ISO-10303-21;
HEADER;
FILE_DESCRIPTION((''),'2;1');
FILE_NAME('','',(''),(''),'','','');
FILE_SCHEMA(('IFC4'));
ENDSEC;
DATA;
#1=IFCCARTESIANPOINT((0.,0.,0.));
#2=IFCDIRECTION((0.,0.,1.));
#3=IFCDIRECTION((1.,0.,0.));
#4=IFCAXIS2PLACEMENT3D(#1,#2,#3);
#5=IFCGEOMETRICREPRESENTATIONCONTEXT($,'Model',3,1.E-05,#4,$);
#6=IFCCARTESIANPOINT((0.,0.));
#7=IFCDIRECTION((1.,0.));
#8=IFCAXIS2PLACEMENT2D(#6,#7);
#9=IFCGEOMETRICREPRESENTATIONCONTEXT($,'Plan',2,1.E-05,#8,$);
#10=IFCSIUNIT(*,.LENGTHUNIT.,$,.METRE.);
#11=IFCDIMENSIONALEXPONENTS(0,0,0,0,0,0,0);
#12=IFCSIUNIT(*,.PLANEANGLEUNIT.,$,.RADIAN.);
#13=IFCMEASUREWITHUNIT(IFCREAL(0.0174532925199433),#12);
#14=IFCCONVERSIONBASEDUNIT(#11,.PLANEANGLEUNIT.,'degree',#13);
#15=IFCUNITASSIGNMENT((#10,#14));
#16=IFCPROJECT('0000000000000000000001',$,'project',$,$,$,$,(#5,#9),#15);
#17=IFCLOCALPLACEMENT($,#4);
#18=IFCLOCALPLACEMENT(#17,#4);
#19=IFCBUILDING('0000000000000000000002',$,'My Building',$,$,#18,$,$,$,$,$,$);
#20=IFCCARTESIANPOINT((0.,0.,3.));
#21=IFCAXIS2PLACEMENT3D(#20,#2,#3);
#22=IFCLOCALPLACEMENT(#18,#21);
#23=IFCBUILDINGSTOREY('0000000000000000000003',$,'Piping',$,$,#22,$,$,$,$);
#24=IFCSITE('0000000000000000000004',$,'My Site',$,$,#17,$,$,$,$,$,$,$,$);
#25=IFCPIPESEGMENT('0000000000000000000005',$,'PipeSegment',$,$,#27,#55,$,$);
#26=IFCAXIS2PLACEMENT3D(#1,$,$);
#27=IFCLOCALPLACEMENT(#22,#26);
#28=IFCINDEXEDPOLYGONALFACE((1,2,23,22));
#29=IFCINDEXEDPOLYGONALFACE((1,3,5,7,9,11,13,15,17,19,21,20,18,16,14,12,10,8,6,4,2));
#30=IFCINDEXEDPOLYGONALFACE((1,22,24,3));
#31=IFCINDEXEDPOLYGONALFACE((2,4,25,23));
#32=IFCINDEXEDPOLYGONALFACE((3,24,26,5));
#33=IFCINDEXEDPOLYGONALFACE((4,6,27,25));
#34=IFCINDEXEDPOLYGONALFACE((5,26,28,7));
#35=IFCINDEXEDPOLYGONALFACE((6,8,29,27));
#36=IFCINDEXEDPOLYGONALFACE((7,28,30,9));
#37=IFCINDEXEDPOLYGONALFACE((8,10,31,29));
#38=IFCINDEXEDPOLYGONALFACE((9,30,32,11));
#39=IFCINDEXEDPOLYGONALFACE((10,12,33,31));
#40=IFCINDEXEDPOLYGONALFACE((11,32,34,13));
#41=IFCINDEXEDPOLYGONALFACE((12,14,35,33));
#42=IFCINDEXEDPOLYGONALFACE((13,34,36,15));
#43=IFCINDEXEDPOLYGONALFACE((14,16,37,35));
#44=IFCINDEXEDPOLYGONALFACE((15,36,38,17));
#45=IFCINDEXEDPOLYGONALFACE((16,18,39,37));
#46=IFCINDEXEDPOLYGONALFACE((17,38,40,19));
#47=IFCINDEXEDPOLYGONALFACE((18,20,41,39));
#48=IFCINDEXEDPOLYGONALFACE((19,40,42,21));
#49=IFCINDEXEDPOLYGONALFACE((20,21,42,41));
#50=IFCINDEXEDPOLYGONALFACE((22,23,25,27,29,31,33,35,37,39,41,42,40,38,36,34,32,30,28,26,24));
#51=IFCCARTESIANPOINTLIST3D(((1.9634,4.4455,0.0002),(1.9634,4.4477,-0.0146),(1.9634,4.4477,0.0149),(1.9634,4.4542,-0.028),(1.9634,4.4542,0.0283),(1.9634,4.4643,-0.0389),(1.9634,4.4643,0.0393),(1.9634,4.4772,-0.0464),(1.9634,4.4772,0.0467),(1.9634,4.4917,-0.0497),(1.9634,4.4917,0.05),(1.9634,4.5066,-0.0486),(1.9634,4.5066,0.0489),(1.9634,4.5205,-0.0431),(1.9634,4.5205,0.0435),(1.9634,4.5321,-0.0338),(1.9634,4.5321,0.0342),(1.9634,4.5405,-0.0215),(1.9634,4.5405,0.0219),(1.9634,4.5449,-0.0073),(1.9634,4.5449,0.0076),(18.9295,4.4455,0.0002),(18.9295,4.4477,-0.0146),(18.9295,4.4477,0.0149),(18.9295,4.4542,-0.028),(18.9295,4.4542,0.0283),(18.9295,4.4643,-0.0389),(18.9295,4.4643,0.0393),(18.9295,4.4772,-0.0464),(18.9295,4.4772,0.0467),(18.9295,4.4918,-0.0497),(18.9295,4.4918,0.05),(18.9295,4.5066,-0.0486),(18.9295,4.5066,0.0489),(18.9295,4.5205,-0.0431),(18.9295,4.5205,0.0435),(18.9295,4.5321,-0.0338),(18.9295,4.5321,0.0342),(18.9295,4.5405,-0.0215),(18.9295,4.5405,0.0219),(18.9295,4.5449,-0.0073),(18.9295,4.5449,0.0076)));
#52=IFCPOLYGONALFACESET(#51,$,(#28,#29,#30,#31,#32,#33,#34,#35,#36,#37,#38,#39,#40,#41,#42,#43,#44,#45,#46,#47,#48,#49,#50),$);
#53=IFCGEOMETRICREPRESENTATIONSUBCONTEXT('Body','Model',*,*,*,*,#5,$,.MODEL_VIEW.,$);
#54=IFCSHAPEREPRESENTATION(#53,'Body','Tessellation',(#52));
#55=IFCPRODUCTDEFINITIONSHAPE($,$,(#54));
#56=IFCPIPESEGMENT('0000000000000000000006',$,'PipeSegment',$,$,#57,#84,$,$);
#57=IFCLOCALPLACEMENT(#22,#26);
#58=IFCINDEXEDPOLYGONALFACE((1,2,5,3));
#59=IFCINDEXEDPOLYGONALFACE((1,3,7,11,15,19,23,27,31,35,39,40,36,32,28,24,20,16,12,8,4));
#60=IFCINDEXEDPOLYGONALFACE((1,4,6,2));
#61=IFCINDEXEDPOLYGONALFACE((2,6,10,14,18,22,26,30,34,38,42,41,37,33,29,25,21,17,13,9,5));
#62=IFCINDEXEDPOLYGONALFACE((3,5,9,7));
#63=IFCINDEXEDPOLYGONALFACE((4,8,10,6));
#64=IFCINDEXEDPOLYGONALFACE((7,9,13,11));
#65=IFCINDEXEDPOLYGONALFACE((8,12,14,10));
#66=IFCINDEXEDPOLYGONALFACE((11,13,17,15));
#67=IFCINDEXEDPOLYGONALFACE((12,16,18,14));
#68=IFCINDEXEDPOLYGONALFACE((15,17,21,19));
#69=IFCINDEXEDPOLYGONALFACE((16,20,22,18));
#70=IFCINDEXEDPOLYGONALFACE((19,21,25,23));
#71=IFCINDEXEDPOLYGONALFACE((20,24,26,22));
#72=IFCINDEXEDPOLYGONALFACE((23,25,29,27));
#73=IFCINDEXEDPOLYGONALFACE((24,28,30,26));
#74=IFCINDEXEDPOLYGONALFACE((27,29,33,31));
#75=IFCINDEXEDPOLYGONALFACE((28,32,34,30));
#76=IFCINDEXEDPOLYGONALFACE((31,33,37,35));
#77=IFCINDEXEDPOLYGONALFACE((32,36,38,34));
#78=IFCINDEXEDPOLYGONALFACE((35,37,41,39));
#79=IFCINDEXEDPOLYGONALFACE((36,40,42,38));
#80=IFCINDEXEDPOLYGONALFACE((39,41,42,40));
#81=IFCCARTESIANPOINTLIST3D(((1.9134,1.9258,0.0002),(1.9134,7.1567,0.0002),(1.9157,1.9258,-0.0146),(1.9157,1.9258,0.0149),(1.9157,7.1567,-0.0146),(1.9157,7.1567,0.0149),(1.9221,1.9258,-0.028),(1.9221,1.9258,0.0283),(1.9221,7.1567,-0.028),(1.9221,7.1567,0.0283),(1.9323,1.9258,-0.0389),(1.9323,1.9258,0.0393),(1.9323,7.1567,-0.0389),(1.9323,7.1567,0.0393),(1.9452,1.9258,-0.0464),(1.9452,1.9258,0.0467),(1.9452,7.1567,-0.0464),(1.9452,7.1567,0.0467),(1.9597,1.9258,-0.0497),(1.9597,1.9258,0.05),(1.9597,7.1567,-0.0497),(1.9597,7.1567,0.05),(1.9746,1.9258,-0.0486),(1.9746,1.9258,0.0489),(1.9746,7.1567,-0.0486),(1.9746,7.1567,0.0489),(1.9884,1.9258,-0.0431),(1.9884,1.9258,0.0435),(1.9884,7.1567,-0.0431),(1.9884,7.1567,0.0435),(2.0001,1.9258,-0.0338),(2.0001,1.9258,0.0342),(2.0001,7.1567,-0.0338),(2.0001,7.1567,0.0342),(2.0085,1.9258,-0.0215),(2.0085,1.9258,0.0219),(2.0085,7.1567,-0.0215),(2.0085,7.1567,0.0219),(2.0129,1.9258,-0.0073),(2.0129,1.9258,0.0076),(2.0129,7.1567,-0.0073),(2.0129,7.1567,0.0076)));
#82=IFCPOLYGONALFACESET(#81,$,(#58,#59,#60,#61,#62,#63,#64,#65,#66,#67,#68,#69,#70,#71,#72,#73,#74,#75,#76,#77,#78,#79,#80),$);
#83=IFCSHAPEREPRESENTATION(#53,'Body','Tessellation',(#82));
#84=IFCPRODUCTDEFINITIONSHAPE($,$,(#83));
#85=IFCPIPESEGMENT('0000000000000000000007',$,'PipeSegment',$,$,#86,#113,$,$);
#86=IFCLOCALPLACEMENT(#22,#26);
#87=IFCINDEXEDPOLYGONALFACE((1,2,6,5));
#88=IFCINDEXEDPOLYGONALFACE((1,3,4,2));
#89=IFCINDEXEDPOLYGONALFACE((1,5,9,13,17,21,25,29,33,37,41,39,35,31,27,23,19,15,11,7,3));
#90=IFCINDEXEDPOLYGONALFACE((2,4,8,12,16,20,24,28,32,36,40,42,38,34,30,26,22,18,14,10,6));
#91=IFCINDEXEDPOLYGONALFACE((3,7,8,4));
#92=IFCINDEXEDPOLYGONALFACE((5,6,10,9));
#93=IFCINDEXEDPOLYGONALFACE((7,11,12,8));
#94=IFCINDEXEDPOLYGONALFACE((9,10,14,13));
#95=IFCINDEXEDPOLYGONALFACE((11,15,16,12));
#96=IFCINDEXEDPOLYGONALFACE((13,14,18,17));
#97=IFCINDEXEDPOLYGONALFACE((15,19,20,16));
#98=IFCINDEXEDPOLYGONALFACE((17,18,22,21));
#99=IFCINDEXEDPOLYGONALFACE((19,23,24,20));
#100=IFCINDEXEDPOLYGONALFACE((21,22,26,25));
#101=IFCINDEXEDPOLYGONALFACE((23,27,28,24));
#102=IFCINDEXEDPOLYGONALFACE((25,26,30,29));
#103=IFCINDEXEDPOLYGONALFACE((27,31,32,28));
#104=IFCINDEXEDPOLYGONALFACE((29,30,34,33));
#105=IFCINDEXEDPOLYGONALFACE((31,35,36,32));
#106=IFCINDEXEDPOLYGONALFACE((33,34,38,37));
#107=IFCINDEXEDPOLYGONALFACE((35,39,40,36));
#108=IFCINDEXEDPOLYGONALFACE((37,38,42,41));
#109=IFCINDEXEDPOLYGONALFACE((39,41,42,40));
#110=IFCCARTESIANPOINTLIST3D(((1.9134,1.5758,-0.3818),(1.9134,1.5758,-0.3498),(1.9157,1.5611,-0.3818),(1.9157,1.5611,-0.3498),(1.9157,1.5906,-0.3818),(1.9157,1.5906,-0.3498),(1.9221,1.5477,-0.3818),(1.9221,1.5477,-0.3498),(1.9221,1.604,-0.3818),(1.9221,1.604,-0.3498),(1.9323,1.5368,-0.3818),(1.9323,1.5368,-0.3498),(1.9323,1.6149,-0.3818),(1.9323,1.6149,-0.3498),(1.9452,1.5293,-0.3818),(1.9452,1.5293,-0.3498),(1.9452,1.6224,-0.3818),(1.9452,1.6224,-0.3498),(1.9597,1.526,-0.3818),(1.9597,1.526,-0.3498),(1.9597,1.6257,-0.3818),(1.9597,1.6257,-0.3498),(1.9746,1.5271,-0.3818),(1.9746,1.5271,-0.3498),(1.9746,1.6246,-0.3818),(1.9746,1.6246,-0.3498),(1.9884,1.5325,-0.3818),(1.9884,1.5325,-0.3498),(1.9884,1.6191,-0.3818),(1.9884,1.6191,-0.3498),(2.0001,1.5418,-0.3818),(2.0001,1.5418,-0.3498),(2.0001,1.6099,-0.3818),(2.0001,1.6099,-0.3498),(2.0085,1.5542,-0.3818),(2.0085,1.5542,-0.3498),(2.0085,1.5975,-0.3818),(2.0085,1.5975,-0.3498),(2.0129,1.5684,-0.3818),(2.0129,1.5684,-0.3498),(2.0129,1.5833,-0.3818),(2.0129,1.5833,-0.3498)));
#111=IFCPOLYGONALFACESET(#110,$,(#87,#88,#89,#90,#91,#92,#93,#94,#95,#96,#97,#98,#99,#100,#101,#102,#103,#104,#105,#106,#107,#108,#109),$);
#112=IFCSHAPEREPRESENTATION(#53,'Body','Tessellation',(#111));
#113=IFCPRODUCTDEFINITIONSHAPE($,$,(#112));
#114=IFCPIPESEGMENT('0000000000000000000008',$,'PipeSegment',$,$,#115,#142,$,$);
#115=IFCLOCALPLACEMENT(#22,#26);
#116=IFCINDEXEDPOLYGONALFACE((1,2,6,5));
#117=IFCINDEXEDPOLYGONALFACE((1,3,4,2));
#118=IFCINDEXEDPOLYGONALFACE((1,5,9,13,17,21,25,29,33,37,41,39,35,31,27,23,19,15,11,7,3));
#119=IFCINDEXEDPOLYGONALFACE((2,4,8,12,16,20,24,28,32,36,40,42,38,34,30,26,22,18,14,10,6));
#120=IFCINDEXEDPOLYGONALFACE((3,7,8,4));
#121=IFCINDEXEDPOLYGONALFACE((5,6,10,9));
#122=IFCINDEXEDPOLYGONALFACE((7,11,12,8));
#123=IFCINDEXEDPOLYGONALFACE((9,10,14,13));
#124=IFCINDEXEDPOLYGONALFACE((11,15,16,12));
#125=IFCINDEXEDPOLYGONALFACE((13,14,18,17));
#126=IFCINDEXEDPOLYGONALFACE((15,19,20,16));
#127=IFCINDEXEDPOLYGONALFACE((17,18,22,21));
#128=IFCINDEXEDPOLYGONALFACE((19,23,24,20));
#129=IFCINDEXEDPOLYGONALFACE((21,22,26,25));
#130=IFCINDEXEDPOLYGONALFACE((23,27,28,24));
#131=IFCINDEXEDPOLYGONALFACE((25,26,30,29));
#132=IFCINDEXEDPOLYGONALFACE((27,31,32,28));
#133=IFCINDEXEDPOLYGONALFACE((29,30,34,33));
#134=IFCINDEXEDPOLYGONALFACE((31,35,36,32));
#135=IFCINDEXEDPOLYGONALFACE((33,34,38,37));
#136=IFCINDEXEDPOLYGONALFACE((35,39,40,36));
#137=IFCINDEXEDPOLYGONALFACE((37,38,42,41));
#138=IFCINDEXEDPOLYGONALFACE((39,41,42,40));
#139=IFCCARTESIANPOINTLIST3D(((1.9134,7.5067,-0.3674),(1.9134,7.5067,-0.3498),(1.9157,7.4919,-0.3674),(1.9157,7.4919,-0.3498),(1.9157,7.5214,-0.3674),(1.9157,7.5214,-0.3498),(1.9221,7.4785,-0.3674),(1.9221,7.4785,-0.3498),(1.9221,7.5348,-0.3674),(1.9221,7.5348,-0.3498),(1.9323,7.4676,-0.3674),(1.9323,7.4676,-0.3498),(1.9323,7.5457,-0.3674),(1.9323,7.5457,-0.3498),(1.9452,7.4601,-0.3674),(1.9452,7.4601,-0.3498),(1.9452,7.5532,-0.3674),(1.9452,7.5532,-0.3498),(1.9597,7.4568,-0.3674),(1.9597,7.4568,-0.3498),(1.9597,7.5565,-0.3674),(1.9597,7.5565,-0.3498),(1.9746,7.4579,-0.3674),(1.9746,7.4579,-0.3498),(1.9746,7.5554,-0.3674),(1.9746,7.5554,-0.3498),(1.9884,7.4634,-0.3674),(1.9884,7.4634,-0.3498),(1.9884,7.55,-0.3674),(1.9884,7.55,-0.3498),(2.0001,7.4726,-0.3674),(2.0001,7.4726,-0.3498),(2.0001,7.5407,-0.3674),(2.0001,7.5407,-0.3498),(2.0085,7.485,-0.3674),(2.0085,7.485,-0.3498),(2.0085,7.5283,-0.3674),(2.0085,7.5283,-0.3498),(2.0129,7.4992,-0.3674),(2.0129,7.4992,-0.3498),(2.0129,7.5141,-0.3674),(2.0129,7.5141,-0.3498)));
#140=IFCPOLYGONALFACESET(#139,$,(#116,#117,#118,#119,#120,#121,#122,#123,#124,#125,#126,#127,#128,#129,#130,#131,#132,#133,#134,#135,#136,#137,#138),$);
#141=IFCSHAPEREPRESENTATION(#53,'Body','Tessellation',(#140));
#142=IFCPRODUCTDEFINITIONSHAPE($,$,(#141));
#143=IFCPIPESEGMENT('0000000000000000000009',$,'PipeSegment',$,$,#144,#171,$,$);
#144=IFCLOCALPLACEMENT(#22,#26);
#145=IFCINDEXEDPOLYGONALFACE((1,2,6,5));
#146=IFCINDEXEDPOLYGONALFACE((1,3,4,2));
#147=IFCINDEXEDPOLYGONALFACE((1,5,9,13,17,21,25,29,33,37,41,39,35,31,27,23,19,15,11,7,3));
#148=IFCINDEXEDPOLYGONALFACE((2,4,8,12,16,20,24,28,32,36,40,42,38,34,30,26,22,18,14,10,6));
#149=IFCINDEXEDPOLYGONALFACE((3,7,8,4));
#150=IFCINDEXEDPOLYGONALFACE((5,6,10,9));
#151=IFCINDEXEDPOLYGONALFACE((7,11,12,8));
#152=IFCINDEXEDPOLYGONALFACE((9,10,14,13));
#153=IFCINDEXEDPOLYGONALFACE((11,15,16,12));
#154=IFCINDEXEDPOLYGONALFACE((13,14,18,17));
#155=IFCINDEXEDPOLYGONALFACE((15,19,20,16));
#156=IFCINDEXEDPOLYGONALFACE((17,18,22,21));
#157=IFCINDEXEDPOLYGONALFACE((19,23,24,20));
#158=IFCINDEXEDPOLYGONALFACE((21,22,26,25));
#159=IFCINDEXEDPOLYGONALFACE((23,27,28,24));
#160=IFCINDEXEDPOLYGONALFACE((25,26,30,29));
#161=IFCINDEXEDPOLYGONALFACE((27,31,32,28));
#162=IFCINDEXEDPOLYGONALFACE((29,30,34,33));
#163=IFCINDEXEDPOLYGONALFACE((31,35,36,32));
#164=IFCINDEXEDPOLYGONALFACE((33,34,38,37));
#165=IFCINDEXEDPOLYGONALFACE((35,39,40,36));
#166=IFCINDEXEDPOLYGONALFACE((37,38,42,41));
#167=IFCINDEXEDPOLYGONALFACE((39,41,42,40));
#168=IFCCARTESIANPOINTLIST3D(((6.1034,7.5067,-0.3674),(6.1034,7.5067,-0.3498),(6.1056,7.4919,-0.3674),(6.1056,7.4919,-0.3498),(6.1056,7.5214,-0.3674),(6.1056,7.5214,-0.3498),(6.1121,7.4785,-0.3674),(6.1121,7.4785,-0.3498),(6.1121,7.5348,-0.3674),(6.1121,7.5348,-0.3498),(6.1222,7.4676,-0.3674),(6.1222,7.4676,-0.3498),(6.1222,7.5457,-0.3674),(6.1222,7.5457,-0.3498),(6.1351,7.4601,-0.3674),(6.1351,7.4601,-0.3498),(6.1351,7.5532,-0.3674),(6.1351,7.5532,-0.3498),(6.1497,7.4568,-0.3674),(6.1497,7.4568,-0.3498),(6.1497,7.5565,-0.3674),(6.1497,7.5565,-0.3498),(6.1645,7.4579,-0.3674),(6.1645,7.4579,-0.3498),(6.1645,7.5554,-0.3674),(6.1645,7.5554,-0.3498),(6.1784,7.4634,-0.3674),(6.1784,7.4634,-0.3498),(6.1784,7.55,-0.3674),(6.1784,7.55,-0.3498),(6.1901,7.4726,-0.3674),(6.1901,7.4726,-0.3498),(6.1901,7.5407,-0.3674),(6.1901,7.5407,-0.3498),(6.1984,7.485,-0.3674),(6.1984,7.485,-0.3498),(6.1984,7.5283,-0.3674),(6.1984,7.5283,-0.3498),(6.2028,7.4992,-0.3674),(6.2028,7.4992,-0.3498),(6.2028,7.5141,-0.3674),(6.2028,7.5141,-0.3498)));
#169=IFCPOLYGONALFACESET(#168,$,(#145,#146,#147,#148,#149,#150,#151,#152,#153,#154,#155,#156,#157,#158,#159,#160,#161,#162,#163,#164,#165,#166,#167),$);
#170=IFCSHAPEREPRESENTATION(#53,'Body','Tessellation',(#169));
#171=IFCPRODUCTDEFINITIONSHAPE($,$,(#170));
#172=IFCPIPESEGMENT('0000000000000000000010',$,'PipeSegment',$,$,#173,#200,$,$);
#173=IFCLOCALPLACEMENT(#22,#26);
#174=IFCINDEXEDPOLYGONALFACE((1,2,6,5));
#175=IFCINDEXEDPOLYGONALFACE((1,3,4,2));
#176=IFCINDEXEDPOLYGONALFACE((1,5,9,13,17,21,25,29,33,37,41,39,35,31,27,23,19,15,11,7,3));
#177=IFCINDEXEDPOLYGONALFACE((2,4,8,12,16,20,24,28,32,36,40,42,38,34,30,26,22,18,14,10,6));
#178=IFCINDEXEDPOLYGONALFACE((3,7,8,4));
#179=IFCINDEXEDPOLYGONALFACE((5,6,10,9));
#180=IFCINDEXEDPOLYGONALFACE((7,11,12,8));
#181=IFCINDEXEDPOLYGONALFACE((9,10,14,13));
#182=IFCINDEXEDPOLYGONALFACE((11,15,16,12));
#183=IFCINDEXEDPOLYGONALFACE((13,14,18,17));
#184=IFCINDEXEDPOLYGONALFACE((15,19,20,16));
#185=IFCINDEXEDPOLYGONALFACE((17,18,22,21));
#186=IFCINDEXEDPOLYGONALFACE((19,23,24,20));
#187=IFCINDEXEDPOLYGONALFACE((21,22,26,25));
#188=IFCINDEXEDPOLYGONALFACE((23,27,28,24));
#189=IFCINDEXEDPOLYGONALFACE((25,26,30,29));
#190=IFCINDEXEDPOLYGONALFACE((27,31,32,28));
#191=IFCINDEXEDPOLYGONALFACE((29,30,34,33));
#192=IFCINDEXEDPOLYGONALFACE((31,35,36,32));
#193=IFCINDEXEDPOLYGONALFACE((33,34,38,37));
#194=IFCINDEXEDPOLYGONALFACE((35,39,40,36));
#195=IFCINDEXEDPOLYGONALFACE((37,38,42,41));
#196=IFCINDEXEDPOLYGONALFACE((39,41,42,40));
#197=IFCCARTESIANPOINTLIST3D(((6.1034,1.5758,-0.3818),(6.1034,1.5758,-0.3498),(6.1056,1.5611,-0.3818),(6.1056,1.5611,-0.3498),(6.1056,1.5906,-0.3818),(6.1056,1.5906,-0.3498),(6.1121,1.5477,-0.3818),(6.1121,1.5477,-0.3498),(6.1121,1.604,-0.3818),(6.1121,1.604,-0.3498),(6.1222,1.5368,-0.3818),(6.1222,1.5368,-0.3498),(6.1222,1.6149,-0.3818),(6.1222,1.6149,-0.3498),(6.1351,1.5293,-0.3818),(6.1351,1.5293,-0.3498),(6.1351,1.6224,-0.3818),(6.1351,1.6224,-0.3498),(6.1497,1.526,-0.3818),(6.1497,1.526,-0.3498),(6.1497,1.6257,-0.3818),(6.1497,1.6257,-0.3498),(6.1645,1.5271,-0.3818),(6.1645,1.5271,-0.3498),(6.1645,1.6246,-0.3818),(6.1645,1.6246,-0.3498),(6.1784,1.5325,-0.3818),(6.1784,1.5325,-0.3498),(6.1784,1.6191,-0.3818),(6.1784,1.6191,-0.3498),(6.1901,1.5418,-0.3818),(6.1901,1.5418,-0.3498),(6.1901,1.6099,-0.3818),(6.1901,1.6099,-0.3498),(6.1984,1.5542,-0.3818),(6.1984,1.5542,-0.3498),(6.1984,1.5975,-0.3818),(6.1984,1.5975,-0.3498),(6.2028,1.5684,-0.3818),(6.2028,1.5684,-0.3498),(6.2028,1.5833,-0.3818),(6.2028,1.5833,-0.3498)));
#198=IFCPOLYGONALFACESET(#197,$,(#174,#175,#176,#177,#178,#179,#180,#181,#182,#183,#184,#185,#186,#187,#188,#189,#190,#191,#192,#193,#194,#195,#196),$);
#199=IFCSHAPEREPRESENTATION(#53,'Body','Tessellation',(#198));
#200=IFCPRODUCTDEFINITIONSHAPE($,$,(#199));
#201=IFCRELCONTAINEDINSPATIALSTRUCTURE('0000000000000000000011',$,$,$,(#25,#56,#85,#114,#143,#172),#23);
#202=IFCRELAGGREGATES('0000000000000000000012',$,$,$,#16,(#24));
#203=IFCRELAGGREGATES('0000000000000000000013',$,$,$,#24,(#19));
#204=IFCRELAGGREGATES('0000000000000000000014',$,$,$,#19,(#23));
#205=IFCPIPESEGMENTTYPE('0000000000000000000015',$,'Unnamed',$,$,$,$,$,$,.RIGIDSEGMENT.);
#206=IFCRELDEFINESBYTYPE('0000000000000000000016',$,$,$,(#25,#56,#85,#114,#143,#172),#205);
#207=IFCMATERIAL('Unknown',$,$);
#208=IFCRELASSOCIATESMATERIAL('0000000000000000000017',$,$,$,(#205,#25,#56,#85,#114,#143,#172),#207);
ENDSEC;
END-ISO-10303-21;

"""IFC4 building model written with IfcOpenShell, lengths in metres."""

from ifc_helpers import new_model, entity, si_unit, converted_unit, frame, origin_with_axes, origin_2d_with_axis, place, context, subcontext, project, spatial, circle, extrude, material, material_profile, profile_set, profile_usage, type_object, element, save


model = new_model("IFC4")

# Units and contexts
model_context = context("Model", 3, precision=1e-05, world=origin_with_axes())
plan_context = context("Plan", 2, precision=1e-05, world=origin_2d_with_axis())
body_context = subcontext(model_context, "Body", "Model", "MODEL_VIEW")
ifc_project = project(units=[si_unit("LENGTHUNIT", "METRE"), converted_unit("PLANEANGLEUNIT", "degree", entity("IfcReal", 0.0174532925199433), si_unit("PLANEANGLEUNIT", "RADIAN"), dimensions=[0, 0, 0, 0, 0, 0, 0])], contexts=[model_context, plan_context])

# Site, building, storey
site_placement = place(None, origin_with_axes())
site = spatial("IfcSite", under=ifc_project, at=site_placement, Name="My Site")
building_placement = place(site_placement, origin_with_axes())
building = spatial("IfcBuilding", under=site, at=building_placement, Name="My Building")
storey_placement = place(building_placement, frame((0.0, 0.0, 3.0), z_axis=(0.0, 0.0, 1.0), x_axis=(1.0, 0.0, 0.0)))
storey = spatial("IfcBuildingStorey", under=building, at=storey_placement, Name="Piping")

# Pipe segments
ifc_material = material(Name="Unknown")
ifc_material_profile = material_profile(ifc_material, circle(Radius=0.05))
ifc_profile_set = profile_set([ifc_material_profile])
ifc_profile_usage_1 = profile_usage(ifc_profile_set, cardinal=5)
pipe_segment_type = type_object("IfcPipeSegmentType", Name="Unnamed", PredefinedType="RIGIDSEGMENT", material=ifc_profile_set)
pipe_segment_1_placement = place(storey_placement, frame((18.9295, 4.4955, 0.0002), z_axis=(-1.0, 0.0, 0.0), x_axis=(0.0, -1.0, 0.0)))
element("IfcPipeSegment", 1, at=pipe_segment_1_placement, inside=storey, type_object=pipe_segment_type, material=ifc_profile_usage_1, Name="PipeSegment", context=body_context, shape_type="SweptSolid", body=[
    extrude(circle(Radius=0.05), origin_with_axes(), (0.0, 0.0, 1.0), 16.966),
])
ifc_profile_usage_2 = profile_usage(ifc_profile_set, cardinal=5)
pipe_segment_2_placement = place(storey_placement, frame((1.9634, 1.9258, 0.0002), z_axis=(0.0, 1.0, 0.0), x_axis=(-1.0, 0.0, 0.0)))
element("IfcPipeSegment", 2, at=pipe_segment_2_placement, inside=storey, type_object=pipe_segment_type, material=ifc_profile_usage_2, Name="PipeSegment", context=body_context, shape_type="SweptSolid", body=[
    extrude(circle(Radius=0.05), origin_with_axes(), (0.0, 0.0, 1.0), 5.2308),
])
ifc_profile_usage_3 = profile_usage(ifc_profile_set, cardinal=5)
pipe_segment_3_placement = place(storey_placement, frame((1.9634, 1.5758, -0.3498), z_axis=(0.0, 0.0, -1.0), x_axis=(-1.0, 0.0, 0.0)))
element("IfcPipeSegment", 3, at=pipe_segment_3_placement, inside=storey, type_object=pipe_segment_type, material=ifc_profile_usage_3, Name="PipeSegment", context=body_context, shape_type="SweptSolid", body=[
    extrude(circle(Radius=0.05), origin_with_axes(), (0.0, 0.0, 1.0), 0.0319),
])
ifc_profile_usage_4 = profile_usage(ifc_profile_set, cardinal=5)
pipe_segment_4_placement = place(storey_placement, frame((1.9634, 7.5067, -0.3498), z_axis=(0.0, 0.0, -1.0), x_axis=(-1.0, 0.0, 0.0)))
element("IfcPipeSegment", 4, at=pipe_segment_4_placement, inside=storey, type_object=pipe_segment_type, material=ifc_profile_usage_4, Name="PipeSegment", context=body_context, shape_type="SweptSolid", body=[
    extrude(circle(Radius=0.05), origin_with_axes(), (0.0, 0.0, 1.0), 0.0175),
])
ifc_profile_usage_5 = profile_usage(ifc_profile_set, cardinal=5)
pipe_segment_5_placement = place(storey_placement, frame((6.1534, 7.5067, -0.3498), z_axis=(0.0, 0.0, -1.0), x_axis=(-1.0, 0.0, 0.0)))
element("IfcPipeSegment", 5, at=pipe_segment_5_placement, inside=storey, type_object=pipe_segment_type, material=ifc_profile_usage_5, Name="PipeSegment", context=body_context, shape_type="SweptSolid", body=[
    extrude(circle(Radius=0.05), origin_with_axes(), (0.0, 0.0, 1.0), 0.0175),
])
ifc_profile_usage_6 = profile_usage(ifc_profile_set, cardinal=5)
pipe_segment_6_placement = place(storey_placement, frame((6.1534, 1.5758, -0.3498), z_axis=(0.0, 0.0, -1.0), x_axis=(-1.0, 0.0, 0.0)))
element("IfcPipeSegment", 6, at=pipe_segment_6_placement, inside=storey, type_object=pipe_segment_type, material=ifc_profile_usage_6, Name="PipeSegment", context=body_context, shape_type="SweptSolid", body=[
    extrude(circle(Radius=0.05), origin_with_axes(), (0.0, 0.0, 1.0), 0.0319),
])

save(model, "model.ifc")
